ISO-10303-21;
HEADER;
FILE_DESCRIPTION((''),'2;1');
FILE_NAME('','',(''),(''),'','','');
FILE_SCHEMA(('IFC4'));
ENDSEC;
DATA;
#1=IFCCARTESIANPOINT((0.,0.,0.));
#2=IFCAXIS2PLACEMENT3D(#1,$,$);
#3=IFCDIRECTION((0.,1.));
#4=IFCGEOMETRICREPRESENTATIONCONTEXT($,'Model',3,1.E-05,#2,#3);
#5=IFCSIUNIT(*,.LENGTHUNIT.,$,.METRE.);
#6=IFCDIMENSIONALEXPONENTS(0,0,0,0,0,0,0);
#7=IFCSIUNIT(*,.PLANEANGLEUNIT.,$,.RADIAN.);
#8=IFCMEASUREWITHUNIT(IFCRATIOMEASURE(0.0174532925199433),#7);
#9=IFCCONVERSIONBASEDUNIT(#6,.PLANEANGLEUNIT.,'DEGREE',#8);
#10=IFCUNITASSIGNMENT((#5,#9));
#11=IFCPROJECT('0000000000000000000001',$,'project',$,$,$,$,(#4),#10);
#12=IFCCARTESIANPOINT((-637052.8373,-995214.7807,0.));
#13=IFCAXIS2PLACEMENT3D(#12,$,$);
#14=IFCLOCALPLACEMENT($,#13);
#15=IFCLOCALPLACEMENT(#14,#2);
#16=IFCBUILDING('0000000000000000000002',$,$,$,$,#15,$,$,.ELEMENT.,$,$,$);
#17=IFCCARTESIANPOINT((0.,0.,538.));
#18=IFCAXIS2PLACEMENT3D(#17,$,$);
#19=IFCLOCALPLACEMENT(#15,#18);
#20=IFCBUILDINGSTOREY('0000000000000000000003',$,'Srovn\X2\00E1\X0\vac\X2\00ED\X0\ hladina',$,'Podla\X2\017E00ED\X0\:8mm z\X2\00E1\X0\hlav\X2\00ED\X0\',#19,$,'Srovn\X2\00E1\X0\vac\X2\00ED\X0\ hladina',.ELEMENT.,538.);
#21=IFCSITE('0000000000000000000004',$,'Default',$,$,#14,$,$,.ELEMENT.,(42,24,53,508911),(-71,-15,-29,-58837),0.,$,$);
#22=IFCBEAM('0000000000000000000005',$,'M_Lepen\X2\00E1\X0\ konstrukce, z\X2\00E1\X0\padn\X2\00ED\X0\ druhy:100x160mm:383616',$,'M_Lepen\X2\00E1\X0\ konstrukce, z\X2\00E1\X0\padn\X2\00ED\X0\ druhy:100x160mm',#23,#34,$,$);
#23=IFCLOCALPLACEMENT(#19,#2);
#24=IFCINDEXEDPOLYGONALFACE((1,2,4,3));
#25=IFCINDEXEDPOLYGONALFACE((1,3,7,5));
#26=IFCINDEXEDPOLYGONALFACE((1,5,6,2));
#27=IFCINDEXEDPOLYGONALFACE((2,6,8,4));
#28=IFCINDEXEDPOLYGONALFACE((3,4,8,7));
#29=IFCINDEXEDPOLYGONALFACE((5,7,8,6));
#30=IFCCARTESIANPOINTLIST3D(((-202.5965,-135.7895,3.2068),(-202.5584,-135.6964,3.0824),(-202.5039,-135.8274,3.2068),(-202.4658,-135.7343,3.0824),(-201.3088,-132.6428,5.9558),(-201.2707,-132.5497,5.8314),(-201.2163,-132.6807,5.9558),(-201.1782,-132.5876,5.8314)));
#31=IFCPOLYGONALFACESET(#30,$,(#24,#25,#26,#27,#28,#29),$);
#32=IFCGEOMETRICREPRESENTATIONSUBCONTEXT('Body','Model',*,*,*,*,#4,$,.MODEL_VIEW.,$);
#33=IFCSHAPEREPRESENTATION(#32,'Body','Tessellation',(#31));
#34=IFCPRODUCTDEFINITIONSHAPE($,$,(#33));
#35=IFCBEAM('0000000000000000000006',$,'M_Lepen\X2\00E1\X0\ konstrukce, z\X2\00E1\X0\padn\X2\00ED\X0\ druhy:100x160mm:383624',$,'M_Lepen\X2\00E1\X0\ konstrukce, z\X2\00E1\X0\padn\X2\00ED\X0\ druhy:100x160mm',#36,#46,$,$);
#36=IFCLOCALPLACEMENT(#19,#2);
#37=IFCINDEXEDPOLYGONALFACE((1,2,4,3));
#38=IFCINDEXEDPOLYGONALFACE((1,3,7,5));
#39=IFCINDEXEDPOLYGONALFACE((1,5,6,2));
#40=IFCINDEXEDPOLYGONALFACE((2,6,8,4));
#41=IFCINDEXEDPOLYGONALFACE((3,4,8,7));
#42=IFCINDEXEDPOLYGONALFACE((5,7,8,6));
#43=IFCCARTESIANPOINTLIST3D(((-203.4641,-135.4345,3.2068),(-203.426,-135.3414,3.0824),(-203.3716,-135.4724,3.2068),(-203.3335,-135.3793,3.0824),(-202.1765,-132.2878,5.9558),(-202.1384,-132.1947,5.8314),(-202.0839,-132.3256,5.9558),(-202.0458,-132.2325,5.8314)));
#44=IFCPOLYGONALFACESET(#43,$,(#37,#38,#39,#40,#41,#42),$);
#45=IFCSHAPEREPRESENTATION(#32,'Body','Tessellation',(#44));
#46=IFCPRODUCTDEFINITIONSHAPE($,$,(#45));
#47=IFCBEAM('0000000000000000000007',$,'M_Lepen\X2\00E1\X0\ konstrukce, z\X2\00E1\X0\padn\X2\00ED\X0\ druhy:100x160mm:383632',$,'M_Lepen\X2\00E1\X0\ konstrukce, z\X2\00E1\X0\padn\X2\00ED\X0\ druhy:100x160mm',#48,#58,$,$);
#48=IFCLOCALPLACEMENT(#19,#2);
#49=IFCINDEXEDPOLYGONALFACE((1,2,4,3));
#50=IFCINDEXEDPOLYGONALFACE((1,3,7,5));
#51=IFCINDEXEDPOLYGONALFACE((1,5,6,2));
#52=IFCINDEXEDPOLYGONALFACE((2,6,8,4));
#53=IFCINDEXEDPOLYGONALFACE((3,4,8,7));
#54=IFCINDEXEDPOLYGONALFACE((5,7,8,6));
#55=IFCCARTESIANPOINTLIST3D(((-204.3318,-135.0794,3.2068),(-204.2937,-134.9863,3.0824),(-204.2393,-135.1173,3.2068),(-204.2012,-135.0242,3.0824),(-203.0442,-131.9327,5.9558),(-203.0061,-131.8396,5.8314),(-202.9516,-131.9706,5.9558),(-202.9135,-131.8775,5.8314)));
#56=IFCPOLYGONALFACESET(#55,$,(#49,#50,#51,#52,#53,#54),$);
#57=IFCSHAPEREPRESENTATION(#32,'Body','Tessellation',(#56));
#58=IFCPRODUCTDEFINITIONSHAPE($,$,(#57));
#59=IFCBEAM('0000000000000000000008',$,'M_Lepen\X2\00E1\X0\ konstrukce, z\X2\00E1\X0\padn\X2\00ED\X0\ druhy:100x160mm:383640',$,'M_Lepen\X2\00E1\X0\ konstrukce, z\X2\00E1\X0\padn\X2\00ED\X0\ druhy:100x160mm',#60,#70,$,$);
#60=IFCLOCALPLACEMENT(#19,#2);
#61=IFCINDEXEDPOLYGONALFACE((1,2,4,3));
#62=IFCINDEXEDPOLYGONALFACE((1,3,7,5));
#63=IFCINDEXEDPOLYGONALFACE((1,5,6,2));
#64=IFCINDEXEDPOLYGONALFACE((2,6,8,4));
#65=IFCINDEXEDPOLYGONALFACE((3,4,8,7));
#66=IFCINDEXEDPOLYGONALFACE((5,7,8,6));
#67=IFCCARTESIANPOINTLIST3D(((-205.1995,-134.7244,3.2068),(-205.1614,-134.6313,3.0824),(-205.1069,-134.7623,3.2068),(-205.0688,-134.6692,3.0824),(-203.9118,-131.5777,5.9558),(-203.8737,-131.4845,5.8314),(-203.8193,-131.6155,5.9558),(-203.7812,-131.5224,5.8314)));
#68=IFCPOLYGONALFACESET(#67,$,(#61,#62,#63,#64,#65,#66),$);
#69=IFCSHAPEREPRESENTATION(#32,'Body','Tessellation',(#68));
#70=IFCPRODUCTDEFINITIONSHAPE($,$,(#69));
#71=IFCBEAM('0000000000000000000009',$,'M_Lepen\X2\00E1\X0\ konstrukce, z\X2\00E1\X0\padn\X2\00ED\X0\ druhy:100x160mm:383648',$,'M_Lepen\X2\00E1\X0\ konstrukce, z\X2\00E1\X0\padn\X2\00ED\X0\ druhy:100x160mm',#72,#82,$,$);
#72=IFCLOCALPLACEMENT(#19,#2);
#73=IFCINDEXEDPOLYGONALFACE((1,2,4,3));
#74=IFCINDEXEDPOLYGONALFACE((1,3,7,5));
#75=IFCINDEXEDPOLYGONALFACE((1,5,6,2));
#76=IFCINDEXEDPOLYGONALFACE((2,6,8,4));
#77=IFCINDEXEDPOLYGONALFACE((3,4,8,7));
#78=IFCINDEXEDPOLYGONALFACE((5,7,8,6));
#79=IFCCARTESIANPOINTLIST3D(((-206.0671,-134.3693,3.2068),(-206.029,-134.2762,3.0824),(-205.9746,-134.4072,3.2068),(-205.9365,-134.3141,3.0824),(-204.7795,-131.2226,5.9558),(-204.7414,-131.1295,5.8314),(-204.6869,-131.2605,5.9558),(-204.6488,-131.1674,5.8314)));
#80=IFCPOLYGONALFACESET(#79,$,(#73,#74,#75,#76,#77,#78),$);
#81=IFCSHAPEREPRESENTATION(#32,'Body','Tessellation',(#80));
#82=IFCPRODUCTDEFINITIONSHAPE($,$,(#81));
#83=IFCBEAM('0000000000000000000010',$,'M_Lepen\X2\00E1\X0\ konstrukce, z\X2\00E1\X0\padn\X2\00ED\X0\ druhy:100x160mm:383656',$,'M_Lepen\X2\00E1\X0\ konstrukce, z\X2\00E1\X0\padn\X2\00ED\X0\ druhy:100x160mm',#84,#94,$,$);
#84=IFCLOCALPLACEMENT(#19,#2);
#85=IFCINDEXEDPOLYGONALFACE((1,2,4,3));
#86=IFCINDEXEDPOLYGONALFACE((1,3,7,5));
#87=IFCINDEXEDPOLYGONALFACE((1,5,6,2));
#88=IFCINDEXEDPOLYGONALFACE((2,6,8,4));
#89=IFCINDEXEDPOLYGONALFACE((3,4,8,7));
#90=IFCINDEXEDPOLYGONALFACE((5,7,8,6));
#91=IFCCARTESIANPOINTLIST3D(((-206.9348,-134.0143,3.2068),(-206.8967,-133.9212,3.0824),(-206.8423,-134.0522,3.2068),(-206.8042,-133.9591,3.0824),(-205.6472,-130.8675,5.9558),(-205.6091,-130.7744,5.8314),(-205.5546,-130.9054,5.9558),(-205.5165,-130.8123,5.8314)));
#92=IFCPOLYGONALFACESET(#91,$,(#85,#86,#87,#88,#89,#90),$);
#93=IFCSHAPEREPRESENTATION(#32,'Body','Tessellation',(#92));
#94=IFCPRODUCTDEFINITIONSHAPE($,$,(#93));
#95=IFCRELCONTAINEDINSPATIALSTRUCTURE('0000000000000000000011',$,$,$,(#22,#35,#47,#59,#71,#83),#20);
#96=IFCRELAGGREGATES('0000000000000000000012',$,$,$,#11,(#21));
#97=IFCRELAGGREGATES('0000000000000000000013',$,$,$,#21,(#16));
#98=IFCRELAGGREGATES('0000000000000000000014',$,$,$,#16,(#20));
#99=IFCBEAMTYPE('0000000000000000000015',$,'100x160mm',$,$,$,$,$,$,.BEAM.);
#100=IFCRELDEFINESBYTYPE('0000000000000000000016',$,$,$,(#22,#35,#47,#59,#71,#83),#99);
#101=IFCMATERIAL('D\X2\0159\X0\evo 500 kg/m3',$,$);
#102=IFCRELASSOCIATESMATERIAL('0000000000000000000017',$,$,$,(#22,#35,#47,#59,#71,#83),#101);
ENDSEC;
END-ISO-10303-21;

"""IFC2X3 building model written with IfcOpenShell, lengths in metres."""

from ifc_helpers import new_model, entity, si_unit, converted_unit, direction, frame, frame_2d, origin, place, context, subcontext, project, spatial, rectangle, extrude, material, type_object, element, save


model = new_model("IFC2X3")

# Units and contexts
model_context = context("Model", 3, precision=1e-05, world=origin(), true_north=direction((0.0, 1.0)))
body_context = subcontext(model_context, "Body", "Model", "MODEL_VIEW")
ifc_project = project(units=[si_unit("LENGTHUNIT", "METRE"), converted_unit("PLANEANGLEUNIT", "DEGREE", entity("IfcRatioMeasure", 0.0174532925199433), si_unit("PLANEANGLEUNIT", "RADIAN"), dimensions=[0, 0, 0, 0, 0, 0, 0])], contexts=[model_context])

# Site, building, storey
site_placement = place(None, frame((-637052.8373, -995214.7807, 0.0)))
site = spatial("IfcSite", under=ifc_project, at=site_placement, Name="Default", CompositionType="ELEMENT", RefLatitude=(42, 24, 53, 508911), RefLongitude=(-71, -15, -29, -58837), RefElevation=0.0)
building_placement = place(site_placement, origin())
building = spatial("IfcBuilding", under=site, at=building_placement, CompositionType="ELEMENT")
storey_placement = place(building_placement, frame((0.0, 0.0, 538.0)))
storey = spatial("IfcBuildingStorey", under=building, at=storey_placement, Name="Srovnávací hladina", ObjectType="Podlaží:8mm záhlaví", LongName="Srovnávací hladina", CompositionType="ELEMENT", Elevation=538.0)

# Beams
ifc_material_1 = material(Name="Dřevo 500 kg/m3")
beam_type_1 = type_object("IfcBeamType", Name="100x160mm", PredefinedType="BEAM")
beam_1_placement = place(storey_placement, frame((-202.5502, -135.8085, 3.2068), z_axis=(-0.238114, -0.581897, 0.777623), x_axis=(0.294503, 0.719698, 0.628731)))
element("IfcBeam", 1, at=beam_1_placement, inside=storey, type_object=beam_type_1, material=ifc_material_1, Name="M_Lepená konstrukce, západní druhy:100x160mm:383616", ObjectType="M_Lepená konstrukce, západní druhy:100x160mm", context=body_context, shape_type="SweptSolid", body=[
    extrude(rectangle(XDim=0.16, YDim=0.1, at=frame_2d((0.0, 0.0), x_axis=(1.0, 0.0))), frame((0.0, 0.0, -0.08), z_axis=(1.0, 0.0, 0.0), x_axis=(0.0, 0.0, -1.0)), (0.0, 0.0, 1.0), 4.3723),
])
beam_2_placement = place(storey_placement, frame((-203.4179, -135.4534, 3.2068), z_axis=(-0.238114, -0.581897, 0.777623), x_axis=(0.294503, 0.719698, 0.628731)))
element("IfcBeam", 2, at=beam_2_placement, inside=storey, type_object=beam_type_1, material=ifc_material_1, Name="M_Lepená konstrukce, západní druhy:100x160mm:383624", ObjectType="M_Lepená konstrukce, západní druhy:100x160mm", context=body_context, shape_type="SweptSolid", body=[
    extrude(rectangle(XDim=0.16, YDim=0.1, at=frame_2d((0.0, 0.0), x_axis=(1.0, 0.0))), frame((0.0, 0.0, -0.08), z_axis=(1.0, 0.0, 0.0), x_axis=(0.0, 0.0, -1.0)), (0.0, 0.0, 1.0), 4.3723),
])
beam_3_placement = place(storey_placement, frame((-204.2855, -135.0984, 3.2068), z_axis=(-0.238114, -0.581897, 0.777623), x_axis=(0.294503, 0.719698, 0.628731)))
element("IfcBeam", 3, at=beam_3_placement, inside=storey, type_object=beam_type_1, material=ifc_material_1, Name="M_Lepená konstrukce, západní druhy:100x160mm:383632", ObjectType="M_Lepená konstrukce, západní druhy:100x160mm", context=body_context, shape_type="SweptSolid", body=[
    extrude(rectangle(XDim=0.16, YDim=0.1, at=frame_2d((0.0, 0.0), x_axis=(1.0, 0.0))), frame((0.0, 0.0, -0.08), z_axis=(1.0, 0.0, 0.0), x_axis=(0.0, 0.0, -1.0)), (0.0, 0.0, 1.0), 4.3723),
])
for number, where, z_axis, x_axis, name in (
    (4, (-205.1532, -134.7433, 3.2068), (-0.238114, -0.581897, 0.777623), (0.294503, 0.719698, 0.628731), "M_Lepená konstrukce, západní druhy:100x160mm:383640"),
    (5, (-206.0209, -134.3883, 3.2068), (-0.238114, -0.581897, 0.777623), (0.294503, 0.719698, 0.628731), "M_Lepená konstrukce, západní druhy:100x160mm:383648"),
):
    element("IfcBeam", number, at=place(storey_placement, frame(where, z_axis=z_axis, x_axis=x_axis)), inside=storey, type_object=beam_type_1, material=ifc_material_1, Name=name, ObjectType="M_Lepená konstrukce, západní druhy:100x160mm", context=body_context, shape_type="SweptSolid", body=[
        extrude(rectangle(XDim=0.16, YDim=0.1, at=frame_2d((0.0, 0.0), x_axis=(1.0, 0.0))), frame((0.0, 0.0, -0.08), z_axis=(1.0, 0.0, 0.0), x_axis=(0.0, 0.0, -1.0)), (0.0, 0.0, 1.0), 4.3723),
    ])
beam_4_placement = place(storey_placement, frame((-206.8885, -134.0332, 3.2068), z_axis=(-0.238114, -0.581897, 0.777623), x_axis=(0.294503, 0.719698, 0.628731)))
element("IfcBeam", 6, at=beam_4_placement, inside=storey, type_object=beam_type_1, material=ifc_material_1, Name="M_Lepená konstrukce, západní druhy:100x160mm:383656", ObjectType="M_Lepená konstrukce, západní druhy:100x160mm", context=body_context, shape_type="SweptSolid", body=[
    extrude(rectangle(XDim=0.16, YDim=0.1, at=frame_2d((0.0, 0.0), x_axis=(1.0, 0.0))), frame((0.0, 0.0, -0.08), z_axis=(1.0, 0.0, 0.0), x_axis=(0.0, 0.0, -1.0)), (0.0, 0.0, 1.0), 4.3723),
])

save(model, "model.ifc")
